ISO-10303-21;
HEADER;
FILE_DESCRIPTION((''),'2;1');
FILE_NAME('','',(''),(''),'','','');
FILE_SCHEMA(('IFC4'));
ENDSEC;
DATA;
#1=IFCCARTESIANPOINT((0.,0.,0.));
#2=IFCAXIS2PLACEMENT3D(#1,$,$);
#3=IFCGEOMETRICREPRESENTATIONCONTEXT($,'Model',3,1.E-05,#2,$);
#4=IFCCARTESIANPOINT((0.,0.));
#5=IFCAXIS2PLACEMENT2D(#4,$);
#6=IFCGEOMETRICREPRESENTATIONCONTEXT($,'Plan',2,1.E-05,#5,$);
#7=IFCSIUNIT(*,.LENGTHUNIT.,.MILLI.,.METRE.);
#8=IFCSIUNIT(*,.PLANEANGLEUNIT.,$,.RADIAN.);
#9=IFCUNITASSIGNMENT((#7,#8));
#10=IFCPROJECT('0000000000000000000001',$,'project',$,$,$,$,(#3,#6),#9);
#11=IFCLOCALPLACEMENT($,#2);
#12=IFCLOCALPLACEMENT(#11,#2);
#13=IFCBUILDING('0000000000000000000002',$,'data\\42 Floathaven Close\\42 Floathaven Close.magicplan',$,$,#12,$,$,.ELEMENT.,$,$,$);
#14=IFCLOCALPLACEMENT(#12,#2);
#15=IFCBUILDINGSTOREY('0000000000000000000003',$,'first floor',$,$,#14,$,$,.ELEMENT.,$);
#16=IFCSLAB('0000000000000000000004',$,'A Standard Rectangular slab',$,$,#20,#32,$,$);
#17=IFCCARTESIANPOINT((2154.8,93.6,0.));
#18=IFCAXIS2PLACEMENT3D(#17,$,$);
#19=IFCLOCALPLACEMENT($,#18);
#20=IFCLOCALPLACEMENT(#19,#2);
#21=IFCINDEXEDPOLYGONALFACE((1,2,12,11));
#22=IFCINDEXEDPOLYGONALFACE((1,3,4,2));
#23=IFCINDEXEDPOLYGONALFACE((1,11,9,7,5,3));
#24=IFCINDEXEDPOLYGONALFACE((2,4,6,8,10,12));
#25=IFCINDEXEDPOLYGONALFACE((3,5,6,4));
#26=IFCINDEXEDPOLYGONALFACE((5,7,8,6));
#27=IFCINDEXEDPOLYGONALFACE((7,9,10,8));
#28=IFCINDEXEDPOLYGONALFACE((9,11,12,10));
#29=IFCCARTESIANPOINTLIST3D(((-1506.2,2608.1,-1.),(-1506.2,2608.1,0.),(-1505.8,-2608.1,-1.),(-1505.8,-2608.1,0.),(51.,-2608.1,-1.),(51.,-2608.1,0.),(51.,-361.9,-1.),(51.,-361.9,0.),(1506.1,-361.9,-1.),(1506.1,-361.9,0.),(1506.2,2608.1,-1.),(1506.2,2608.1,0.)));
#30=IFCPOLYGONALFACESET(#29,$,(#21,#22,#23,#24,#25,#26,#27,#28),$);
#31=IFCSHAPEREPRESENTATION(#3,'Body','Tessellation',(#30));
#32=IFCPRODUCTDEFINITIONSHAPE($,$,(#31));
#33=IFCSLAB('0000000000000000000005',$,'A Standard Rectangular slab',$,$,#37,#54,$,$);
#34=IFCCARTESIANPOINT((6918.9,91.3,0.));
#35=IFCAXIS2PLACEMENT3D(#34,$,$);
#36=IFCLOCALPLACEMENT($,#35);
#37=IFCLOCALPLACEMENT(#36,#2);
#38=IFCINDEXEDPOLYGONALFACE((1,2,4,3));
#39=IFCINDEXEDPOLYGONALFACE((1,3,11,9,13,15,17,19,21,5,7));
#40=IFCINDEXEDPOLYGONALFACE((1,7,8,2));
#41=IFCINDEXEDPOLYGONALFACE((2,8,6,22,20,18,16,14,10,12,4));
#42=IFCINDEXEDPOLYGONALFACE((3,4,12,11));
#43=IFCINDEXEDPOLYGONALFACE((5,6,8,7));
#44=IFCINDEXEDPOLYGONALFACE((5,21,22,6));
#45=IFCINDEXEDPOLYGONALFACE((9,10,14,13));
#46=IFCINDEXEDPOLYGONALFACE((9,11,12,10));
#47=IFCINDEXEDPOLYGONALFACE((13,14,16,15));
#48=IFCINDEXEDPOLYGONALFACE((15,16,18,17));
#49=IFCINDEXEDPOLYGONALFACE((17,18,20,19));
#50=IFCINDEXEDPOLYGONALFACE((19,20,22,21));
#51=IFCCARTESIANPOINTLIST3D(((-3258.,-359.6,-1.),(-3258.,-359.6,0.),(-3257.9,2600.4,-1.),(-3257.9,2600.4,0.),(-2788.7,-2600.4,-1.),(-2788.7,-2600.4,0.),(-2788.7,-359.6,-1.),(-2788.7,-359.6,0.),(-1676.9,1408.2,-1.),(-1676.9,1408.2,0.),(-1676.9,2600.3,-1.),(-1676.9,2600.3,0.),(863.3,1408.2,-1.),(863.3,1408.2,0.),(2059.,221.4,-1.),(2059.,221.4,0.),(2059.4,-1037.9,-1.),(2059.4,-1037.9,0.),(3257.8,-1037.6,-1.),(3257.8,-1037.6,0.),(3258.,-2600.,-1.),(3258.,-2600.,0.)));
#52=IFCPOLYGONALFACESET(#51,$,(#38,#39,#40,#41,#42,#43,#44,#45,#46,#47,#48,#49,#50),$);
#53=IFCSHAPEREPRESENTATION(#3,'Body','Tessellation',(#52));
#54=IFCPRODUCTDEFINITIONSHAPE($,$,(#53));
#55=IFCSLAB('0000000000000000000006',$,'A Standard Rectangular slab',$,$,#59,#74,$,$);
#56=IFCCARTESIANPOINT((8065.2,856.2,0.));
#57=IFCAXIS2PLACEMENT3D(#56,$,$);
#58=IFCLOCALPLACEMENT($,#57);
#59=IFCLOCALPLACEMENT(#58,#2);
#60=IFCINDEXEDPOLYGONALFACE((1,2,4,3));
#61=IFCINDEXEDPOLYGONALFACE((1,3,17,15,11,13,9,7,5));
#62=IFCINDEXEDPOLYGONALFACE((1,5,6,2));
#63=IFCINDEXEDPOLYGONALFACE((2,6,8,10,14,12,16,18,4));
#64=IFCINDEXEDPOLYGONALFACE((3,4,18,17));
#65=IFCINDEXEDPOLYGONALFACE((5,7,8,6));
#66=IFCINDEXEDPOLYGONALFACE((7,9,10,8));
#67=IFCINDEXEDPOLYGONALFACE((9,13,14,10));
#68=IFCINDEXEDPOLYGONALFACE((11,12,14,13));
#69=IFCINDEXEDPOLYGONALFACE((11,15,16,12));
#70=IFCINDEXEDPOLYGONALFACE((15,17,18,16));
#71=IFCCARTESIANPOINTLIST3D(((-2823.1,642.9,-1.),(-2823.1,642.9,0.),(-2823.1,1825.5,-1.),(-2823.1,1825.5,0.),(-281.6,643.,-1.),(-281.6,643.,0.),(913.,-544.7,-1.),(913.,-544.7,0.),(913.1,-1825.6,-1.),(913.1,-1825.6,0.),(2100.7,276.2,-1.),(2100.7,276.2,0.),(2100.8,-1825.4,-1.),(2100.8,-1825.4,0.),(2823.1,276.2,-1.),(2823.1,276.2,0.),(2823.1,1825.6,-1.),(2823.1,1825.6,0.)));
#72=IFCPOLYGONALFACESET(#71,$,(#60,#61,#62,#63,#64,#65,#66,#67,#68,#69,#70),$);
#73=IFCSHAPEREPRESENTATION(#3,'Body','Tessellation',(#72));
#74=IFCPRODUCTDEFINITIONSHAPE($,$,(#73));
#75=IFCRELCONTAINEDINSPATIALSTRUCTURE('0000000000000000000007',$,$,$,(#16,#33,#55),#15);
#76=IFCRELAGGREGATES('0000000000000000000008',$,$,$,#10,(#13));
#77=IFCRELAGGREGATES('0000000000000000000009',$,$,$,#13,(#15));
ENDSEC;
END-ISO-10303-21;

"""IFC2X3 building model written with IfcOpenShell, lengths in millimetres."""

from ifc_helpers import new_model, si_unit, frame, origin, origin_2d, place, context, project, spatial, polyline, outline, extrude, element, save


model = new_model("IFC2X3")

# Units and contexts
model_context = context("Model", 3, precision=1e-05, world=origin())
plan_context = context("Plan", 2, precision=1e-05, world=origin_2d())
ifc_project = project(units=[si_unit("LENGTHUNIT", "METRE", prefix="MILLI"), si_unit("PLANEANGLEUNIT", "RADIAN")], contexts=[model_context, plan_context])

# Building, storey
placement_1 = place(None, origin())
building_placement = place(placement_1, origin())
building = spatial("IfcBuilding", under=ifc_project, at=building_placement, Name="data\\42 Floathaven Close\\42 Floathaven Close.magicplan", CompositionType="ELEMENT")
storey_placement = place(building_placement, origin())
storey = spatial("IfcBuildingStorey", under=building, at=storey_placement, Name="first floor", CompositionType="ELEMENT")

# Slabs
placement_2 = place(None, frame((2154.8, 93.6, 0.0)))
slab_1_placement = place(placement_2, origin())
element("IfcSlab", 1, at=slab_1_placement, inside=storey, Name="A Standard Rectangular slab", context=model_context, shape_type="SweptSolid", body=[
    extrude(outline(polyline([(-1505.8, -2608.1, 0.0), (-1506.2, 2608.1, 0.0), (1506.2, 2608.1, 0.0), (1506.1, -361.9, 0.0), (51.0, -361.9, 0.0), (51.0, -2608.1, 0.0), (-1505.8, -2608.1, 0.0)]), kind="CURVE"), origin(), (0.0, 0.0, -1.0), 1.0),
])
placement_3 = place(None, frame((6918.9, 91.3, 0.0)))
slab_2_placement = place(placement_3, origin())
element("IfcSlab", 2, at=slab_2_placement, inside=storey, Name="A Standard Rectangular slab", context=model_context, shape_type="SweptSolid", body=[
    extrude(outline(polyline([(3258.0, -2600.0, 0.0), (-2788.7, -2600.4, 0.0), (-2788.7, -359.6, 0.0), (-3258.0, -359.6, 0.0), (-3257.9, 2600.4, 0.0), (-1676.9, 2600.3, 0.0), (-1676.9, 1408.2, 0.0), (863.3, 1408.2, 0.0), (2059.1, 221.4, 0.0), (2059.4, -1037.9, 0.0), (3257.8, -1037.6, 0.0), (3258.0, -2600.0, 0.0)]), kind="CURVE"), origin(), (0.0, 0.0, -1.0), 1.0),
])
placement_4 = place(None, frame((8065.2, 856.2, 0.0)))
slab_3_placement = place(placement_4, origin())
element("IfcSlab", 3, at=slab_3_placement, inside=storey, Name="A Standard Rectangular slab", context=model_context, shape_type="SweptSolid", body=[
    extrude(outline(polyline([(913.1, -1825.6, 0.0), (913.0, -544.7, 0.0), (-281.6, 643.0, 0.0), (-2823.1, 642.9, 0.0), (-2823.1, 1825.5, 0.0), (2823.1, 1825.6, 0.0), (2823.1, 276.2, 0.0), (2100.8, 276.2, 0.0), (2100.8, -1825.4, 0.0), (913.1, -1825.6, 0.0)]), kind="CURVE"), origin(), (0.0, 0.0, -1.0), 1.0),
])

save(model, "model.ifc")
